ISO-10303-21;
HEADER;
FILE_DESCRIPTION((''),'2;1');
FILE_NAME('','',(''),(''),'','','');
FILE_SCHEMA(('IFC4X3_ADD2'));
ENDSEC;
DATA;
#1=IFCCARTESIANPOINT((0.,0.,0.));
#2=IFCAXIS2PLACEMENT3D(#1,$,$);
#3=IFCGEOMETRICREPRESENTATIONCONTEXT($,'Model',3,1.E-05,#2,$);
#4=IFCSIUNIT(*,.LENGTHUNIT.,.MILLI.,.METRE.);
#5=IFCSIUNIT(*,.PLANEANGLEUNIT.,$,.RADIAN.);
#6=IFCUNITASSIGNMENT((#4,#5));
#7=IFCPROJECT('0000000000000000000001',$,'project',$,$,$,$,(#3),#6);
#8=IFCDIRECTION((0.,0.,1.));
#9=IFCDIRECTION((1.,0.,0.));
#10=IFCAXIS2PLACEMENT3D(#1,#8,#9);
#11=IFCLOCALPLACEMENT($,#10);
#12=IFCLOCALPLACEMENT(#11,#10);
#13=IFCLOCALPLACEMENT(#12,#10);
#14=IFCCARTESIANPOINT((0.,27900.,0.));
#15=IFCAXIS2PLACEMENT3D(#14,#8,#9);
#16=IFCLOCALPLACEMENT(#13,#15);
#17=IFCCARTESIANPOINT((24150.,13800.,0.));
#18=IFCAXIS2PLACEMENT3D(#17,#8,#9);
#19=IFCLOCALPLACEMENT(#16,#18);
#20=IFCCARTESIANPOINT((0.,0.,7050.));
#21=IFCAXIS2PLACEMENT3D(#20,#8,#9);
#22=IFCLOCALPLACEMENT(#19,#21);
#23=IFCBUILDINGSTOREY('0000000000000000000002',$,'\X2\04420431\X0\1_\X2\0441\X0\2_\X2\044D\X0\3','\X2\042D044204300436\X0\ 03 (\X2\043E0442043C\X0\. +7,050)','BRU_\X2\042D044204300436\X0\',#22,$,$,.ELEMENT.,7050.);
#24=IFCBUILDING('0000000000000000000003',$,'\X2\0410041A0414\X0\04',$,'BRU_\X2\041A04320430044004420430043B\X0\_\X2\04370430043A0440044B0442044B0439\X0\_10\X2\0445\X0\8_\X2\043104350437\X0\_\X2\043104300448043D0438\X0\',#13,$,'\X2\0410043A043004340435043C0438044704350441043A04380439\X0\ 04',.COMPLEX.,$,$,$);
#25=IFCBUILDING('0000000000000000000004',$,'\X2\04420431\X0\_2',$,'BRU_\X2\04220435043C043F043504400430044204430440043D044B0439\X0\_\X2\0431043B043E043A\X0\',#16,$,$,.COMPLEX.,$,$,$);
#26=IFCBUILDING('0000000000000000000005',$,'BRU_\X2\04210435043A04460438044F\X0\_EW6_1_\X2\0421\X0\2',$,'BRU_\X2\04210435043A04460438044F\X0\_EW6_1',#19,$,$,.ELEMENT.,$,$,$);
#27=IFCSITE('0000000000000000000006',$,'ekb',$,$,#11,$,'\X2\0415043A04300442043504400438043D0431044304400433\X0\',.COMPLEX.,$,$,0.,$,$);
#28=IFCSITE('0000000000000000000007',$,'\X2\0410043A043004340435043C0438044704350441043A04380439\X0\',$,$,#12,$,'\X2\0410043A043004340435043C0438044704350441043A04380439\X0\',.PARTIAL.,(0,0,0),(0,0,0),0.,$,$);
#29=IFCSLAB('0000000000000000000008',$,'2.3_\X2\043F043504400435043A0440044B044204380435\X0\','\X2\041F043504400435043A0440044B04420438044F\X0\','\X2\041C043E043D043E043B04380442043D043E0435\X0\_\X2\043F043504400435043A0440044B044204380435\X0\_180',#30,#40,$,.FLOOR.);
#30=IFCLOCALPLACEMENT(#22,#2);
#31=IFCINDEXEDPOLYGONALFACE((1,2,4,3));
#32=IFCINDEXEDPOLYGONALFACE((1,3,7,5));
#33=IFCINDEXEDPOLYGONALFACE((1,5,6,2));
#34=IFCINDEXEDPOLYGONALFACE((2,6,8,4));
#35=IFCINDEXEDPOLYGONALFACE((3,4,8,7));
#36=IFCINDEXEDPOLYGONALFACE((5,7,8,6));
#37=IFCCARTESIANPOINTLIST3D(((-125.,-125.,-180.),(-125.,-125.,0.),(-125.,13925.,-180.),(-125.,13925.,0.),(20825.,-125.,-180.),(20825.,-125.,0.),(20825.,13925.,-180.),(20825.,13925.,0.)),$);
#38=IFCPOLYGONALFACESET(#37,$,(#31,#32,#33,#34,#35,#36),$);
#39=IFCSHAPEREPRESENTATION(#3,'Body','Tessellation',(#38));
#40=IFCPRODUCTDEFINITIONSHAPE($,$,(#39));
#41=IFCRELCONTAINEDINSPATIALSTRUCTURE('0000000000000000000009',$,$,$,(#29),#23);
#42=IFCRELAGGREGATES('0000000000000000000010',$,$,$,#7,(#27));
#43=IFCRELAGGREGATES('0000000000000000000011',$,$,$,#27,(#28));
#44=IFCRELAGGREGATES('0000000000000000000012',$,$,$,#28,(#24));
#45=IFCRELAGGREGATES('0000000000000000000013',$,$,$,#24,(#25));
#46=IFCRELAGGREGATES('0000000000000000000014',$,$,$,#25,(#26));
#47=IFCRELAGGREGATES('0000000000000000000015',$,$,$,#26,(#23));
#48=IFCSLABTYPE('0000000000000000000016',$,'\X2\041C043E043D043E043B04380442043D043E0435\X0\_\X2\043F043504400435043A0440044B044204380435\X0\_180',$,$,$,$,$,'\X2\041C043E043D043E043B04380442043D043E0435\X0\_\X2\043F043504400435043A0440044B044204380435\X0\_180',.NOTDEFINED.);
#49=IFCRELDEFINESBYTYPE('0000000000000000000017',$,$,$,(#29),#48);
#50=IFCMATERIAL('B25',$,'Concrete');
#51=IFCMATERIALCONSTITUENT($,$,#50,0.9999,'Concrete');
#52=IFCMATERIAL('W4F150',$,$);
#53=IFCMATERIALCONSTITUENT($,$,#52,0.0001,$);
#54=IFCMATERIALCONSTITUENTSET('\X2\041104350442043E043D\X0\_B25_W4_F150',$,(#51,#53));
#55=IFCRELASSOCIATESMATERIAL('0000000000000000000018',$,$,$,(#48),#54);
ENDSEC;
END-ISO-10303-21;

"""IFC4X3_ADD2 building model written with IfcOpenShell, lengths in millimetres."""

from ifc_helpers import new_model, si_unit, frame, origin, origin_with_axes, place, context, project, spatial, polyline, outline, extrude, material, constituent, constituent_set, type_object, element, save


model = new_model("IFC4X3_ADD2")

# Units and contexts
model_context = context("Model", 3, precision=1e-05, world=origin())
ifc_project = project(units=[si_unit("LENGTHUNIT", "METRE", prefix="MILLI"), si_unit("PLANEANGLEUNIT", "RADIAN")], contexts=[model_context])

# Sites, buildings, storey
site_1_placement = place(None, origin_with_axes())
site_1 = spatial("IfcSite", under=ifc_project, at=site_1_placement, Name="ekb", LongName="Екатеринбург", CompositionType="COMPLEX", RefElevation=0.0)
site_2_placement = place(site_1_placement, origin_with_axes())
site_2 = spatial("IfcSite", under=site_1, at=site_2_placement, Name="Академический", LongName="Академический", CompositionType="PARTIAL", RefLatitude=(0, 0, 0), RefLongitude=(0, 0, 0), RefElevation=0.0)
building_1_placement = place(site_2_placement, origin_with_axes())
building_1 = spatial("IfcBuilding", under=site_2, at=building_1_placement, Name="АКД04", ObjectType="BRU_Квартал_закрытый_10х8_без_башни", LongName="Академический 04", CompositionType="COMPLEX")
building_2_placement = place(building_1_placement, frame((0.0, 27900.0, 0.0), z_axis=(0.0, 0.0, 1.0), x_axis=(1.0, 0.0, 0.0)))
building_2 = spatial("IfcBuilding", under=building_1, at=building_2_placement, Name="тб_2", ObjectType="BRU_Температурный_блок", CompositionType="COMPLEX")
building_3_placement = place(building_2_placement, frame((24150.0, 13800.0, 0.0), z_axis=(0.0, 0.0, 1.0), x_axis=(1.0, 0.0, 0.0)))
building_3 = spatial("IfcBuilding", under=building_2, at=building_3_placement, Name="BRU_Секция_EW6_1_С2", ObjectType="BRU_Секция_EW6_1", CompositionType="ELEMENT")
storey_placement = place(building_3_placement, frame((0.0, 0.0, 7050.0), z_axis=(0.0, 0.0, 1.0), x_axis=(1.0, 0.0, 0.0)))
storey = spatial("IfcBuildingStorey", under=building_3, at=storey_placement, Name="тб1_с2_э3", Description="Этаж 03 (отм. +7,050)", ObjectType="BRU_Этаж", CompositionType="ELEMENT", Elevation=7050.0)

# Shared definitions
ifc_material_1 = material(Name="B25", Category="Concrete")
ifc_material_2 = material(Name="W4F150")

# Slab
ifc_constituent_1 = constituent(ifc_material_1, Category="Concrete", fraction=0.9999)
ifc_constituent_2 = constituent(ifc_material_2, fraction=0.0001)
ifc_constituent_set_1 = constituent_set(constituents=[ifc_constituent_1, ifc_constituent_2], Name="Бетон_B25_W4_F150")
slab_type = type_object("IfcSlabType", Name="Монолитное_перекрытие_180", ElementType="Монолитное_перекрытие_180", PredefinedType="NOTDEFINED", material=ifc_constituent_set_1)
slab_placement = place(storey_placement, frame((0.0, 0.0, -180.0), z_axis=(0.0, 0.0, 1.0), x_axis=(1.0, 0.0, 0.0)))
element("IfcSlab", 1, at=slab_placement, inside=storey, type_object=slab_type, Name="2.3_перекрытие", Description="Перекрытия", ObjectType="Монолитное_перекрытие_180", PredefinedType="FLOOR", context=model_context, shape_type="SweptSolid", body=[
    extrude(outline(polyline([(-125.0, -125.0), (20825.0, -125.0), (20825.0, 13925.0), (-125.0, 13925.0), (-125.0, -125.0)])), origin_with_axes(), (0.0, 0.0, 1.0), 180.0),
])

save(model, "model.ifc")
